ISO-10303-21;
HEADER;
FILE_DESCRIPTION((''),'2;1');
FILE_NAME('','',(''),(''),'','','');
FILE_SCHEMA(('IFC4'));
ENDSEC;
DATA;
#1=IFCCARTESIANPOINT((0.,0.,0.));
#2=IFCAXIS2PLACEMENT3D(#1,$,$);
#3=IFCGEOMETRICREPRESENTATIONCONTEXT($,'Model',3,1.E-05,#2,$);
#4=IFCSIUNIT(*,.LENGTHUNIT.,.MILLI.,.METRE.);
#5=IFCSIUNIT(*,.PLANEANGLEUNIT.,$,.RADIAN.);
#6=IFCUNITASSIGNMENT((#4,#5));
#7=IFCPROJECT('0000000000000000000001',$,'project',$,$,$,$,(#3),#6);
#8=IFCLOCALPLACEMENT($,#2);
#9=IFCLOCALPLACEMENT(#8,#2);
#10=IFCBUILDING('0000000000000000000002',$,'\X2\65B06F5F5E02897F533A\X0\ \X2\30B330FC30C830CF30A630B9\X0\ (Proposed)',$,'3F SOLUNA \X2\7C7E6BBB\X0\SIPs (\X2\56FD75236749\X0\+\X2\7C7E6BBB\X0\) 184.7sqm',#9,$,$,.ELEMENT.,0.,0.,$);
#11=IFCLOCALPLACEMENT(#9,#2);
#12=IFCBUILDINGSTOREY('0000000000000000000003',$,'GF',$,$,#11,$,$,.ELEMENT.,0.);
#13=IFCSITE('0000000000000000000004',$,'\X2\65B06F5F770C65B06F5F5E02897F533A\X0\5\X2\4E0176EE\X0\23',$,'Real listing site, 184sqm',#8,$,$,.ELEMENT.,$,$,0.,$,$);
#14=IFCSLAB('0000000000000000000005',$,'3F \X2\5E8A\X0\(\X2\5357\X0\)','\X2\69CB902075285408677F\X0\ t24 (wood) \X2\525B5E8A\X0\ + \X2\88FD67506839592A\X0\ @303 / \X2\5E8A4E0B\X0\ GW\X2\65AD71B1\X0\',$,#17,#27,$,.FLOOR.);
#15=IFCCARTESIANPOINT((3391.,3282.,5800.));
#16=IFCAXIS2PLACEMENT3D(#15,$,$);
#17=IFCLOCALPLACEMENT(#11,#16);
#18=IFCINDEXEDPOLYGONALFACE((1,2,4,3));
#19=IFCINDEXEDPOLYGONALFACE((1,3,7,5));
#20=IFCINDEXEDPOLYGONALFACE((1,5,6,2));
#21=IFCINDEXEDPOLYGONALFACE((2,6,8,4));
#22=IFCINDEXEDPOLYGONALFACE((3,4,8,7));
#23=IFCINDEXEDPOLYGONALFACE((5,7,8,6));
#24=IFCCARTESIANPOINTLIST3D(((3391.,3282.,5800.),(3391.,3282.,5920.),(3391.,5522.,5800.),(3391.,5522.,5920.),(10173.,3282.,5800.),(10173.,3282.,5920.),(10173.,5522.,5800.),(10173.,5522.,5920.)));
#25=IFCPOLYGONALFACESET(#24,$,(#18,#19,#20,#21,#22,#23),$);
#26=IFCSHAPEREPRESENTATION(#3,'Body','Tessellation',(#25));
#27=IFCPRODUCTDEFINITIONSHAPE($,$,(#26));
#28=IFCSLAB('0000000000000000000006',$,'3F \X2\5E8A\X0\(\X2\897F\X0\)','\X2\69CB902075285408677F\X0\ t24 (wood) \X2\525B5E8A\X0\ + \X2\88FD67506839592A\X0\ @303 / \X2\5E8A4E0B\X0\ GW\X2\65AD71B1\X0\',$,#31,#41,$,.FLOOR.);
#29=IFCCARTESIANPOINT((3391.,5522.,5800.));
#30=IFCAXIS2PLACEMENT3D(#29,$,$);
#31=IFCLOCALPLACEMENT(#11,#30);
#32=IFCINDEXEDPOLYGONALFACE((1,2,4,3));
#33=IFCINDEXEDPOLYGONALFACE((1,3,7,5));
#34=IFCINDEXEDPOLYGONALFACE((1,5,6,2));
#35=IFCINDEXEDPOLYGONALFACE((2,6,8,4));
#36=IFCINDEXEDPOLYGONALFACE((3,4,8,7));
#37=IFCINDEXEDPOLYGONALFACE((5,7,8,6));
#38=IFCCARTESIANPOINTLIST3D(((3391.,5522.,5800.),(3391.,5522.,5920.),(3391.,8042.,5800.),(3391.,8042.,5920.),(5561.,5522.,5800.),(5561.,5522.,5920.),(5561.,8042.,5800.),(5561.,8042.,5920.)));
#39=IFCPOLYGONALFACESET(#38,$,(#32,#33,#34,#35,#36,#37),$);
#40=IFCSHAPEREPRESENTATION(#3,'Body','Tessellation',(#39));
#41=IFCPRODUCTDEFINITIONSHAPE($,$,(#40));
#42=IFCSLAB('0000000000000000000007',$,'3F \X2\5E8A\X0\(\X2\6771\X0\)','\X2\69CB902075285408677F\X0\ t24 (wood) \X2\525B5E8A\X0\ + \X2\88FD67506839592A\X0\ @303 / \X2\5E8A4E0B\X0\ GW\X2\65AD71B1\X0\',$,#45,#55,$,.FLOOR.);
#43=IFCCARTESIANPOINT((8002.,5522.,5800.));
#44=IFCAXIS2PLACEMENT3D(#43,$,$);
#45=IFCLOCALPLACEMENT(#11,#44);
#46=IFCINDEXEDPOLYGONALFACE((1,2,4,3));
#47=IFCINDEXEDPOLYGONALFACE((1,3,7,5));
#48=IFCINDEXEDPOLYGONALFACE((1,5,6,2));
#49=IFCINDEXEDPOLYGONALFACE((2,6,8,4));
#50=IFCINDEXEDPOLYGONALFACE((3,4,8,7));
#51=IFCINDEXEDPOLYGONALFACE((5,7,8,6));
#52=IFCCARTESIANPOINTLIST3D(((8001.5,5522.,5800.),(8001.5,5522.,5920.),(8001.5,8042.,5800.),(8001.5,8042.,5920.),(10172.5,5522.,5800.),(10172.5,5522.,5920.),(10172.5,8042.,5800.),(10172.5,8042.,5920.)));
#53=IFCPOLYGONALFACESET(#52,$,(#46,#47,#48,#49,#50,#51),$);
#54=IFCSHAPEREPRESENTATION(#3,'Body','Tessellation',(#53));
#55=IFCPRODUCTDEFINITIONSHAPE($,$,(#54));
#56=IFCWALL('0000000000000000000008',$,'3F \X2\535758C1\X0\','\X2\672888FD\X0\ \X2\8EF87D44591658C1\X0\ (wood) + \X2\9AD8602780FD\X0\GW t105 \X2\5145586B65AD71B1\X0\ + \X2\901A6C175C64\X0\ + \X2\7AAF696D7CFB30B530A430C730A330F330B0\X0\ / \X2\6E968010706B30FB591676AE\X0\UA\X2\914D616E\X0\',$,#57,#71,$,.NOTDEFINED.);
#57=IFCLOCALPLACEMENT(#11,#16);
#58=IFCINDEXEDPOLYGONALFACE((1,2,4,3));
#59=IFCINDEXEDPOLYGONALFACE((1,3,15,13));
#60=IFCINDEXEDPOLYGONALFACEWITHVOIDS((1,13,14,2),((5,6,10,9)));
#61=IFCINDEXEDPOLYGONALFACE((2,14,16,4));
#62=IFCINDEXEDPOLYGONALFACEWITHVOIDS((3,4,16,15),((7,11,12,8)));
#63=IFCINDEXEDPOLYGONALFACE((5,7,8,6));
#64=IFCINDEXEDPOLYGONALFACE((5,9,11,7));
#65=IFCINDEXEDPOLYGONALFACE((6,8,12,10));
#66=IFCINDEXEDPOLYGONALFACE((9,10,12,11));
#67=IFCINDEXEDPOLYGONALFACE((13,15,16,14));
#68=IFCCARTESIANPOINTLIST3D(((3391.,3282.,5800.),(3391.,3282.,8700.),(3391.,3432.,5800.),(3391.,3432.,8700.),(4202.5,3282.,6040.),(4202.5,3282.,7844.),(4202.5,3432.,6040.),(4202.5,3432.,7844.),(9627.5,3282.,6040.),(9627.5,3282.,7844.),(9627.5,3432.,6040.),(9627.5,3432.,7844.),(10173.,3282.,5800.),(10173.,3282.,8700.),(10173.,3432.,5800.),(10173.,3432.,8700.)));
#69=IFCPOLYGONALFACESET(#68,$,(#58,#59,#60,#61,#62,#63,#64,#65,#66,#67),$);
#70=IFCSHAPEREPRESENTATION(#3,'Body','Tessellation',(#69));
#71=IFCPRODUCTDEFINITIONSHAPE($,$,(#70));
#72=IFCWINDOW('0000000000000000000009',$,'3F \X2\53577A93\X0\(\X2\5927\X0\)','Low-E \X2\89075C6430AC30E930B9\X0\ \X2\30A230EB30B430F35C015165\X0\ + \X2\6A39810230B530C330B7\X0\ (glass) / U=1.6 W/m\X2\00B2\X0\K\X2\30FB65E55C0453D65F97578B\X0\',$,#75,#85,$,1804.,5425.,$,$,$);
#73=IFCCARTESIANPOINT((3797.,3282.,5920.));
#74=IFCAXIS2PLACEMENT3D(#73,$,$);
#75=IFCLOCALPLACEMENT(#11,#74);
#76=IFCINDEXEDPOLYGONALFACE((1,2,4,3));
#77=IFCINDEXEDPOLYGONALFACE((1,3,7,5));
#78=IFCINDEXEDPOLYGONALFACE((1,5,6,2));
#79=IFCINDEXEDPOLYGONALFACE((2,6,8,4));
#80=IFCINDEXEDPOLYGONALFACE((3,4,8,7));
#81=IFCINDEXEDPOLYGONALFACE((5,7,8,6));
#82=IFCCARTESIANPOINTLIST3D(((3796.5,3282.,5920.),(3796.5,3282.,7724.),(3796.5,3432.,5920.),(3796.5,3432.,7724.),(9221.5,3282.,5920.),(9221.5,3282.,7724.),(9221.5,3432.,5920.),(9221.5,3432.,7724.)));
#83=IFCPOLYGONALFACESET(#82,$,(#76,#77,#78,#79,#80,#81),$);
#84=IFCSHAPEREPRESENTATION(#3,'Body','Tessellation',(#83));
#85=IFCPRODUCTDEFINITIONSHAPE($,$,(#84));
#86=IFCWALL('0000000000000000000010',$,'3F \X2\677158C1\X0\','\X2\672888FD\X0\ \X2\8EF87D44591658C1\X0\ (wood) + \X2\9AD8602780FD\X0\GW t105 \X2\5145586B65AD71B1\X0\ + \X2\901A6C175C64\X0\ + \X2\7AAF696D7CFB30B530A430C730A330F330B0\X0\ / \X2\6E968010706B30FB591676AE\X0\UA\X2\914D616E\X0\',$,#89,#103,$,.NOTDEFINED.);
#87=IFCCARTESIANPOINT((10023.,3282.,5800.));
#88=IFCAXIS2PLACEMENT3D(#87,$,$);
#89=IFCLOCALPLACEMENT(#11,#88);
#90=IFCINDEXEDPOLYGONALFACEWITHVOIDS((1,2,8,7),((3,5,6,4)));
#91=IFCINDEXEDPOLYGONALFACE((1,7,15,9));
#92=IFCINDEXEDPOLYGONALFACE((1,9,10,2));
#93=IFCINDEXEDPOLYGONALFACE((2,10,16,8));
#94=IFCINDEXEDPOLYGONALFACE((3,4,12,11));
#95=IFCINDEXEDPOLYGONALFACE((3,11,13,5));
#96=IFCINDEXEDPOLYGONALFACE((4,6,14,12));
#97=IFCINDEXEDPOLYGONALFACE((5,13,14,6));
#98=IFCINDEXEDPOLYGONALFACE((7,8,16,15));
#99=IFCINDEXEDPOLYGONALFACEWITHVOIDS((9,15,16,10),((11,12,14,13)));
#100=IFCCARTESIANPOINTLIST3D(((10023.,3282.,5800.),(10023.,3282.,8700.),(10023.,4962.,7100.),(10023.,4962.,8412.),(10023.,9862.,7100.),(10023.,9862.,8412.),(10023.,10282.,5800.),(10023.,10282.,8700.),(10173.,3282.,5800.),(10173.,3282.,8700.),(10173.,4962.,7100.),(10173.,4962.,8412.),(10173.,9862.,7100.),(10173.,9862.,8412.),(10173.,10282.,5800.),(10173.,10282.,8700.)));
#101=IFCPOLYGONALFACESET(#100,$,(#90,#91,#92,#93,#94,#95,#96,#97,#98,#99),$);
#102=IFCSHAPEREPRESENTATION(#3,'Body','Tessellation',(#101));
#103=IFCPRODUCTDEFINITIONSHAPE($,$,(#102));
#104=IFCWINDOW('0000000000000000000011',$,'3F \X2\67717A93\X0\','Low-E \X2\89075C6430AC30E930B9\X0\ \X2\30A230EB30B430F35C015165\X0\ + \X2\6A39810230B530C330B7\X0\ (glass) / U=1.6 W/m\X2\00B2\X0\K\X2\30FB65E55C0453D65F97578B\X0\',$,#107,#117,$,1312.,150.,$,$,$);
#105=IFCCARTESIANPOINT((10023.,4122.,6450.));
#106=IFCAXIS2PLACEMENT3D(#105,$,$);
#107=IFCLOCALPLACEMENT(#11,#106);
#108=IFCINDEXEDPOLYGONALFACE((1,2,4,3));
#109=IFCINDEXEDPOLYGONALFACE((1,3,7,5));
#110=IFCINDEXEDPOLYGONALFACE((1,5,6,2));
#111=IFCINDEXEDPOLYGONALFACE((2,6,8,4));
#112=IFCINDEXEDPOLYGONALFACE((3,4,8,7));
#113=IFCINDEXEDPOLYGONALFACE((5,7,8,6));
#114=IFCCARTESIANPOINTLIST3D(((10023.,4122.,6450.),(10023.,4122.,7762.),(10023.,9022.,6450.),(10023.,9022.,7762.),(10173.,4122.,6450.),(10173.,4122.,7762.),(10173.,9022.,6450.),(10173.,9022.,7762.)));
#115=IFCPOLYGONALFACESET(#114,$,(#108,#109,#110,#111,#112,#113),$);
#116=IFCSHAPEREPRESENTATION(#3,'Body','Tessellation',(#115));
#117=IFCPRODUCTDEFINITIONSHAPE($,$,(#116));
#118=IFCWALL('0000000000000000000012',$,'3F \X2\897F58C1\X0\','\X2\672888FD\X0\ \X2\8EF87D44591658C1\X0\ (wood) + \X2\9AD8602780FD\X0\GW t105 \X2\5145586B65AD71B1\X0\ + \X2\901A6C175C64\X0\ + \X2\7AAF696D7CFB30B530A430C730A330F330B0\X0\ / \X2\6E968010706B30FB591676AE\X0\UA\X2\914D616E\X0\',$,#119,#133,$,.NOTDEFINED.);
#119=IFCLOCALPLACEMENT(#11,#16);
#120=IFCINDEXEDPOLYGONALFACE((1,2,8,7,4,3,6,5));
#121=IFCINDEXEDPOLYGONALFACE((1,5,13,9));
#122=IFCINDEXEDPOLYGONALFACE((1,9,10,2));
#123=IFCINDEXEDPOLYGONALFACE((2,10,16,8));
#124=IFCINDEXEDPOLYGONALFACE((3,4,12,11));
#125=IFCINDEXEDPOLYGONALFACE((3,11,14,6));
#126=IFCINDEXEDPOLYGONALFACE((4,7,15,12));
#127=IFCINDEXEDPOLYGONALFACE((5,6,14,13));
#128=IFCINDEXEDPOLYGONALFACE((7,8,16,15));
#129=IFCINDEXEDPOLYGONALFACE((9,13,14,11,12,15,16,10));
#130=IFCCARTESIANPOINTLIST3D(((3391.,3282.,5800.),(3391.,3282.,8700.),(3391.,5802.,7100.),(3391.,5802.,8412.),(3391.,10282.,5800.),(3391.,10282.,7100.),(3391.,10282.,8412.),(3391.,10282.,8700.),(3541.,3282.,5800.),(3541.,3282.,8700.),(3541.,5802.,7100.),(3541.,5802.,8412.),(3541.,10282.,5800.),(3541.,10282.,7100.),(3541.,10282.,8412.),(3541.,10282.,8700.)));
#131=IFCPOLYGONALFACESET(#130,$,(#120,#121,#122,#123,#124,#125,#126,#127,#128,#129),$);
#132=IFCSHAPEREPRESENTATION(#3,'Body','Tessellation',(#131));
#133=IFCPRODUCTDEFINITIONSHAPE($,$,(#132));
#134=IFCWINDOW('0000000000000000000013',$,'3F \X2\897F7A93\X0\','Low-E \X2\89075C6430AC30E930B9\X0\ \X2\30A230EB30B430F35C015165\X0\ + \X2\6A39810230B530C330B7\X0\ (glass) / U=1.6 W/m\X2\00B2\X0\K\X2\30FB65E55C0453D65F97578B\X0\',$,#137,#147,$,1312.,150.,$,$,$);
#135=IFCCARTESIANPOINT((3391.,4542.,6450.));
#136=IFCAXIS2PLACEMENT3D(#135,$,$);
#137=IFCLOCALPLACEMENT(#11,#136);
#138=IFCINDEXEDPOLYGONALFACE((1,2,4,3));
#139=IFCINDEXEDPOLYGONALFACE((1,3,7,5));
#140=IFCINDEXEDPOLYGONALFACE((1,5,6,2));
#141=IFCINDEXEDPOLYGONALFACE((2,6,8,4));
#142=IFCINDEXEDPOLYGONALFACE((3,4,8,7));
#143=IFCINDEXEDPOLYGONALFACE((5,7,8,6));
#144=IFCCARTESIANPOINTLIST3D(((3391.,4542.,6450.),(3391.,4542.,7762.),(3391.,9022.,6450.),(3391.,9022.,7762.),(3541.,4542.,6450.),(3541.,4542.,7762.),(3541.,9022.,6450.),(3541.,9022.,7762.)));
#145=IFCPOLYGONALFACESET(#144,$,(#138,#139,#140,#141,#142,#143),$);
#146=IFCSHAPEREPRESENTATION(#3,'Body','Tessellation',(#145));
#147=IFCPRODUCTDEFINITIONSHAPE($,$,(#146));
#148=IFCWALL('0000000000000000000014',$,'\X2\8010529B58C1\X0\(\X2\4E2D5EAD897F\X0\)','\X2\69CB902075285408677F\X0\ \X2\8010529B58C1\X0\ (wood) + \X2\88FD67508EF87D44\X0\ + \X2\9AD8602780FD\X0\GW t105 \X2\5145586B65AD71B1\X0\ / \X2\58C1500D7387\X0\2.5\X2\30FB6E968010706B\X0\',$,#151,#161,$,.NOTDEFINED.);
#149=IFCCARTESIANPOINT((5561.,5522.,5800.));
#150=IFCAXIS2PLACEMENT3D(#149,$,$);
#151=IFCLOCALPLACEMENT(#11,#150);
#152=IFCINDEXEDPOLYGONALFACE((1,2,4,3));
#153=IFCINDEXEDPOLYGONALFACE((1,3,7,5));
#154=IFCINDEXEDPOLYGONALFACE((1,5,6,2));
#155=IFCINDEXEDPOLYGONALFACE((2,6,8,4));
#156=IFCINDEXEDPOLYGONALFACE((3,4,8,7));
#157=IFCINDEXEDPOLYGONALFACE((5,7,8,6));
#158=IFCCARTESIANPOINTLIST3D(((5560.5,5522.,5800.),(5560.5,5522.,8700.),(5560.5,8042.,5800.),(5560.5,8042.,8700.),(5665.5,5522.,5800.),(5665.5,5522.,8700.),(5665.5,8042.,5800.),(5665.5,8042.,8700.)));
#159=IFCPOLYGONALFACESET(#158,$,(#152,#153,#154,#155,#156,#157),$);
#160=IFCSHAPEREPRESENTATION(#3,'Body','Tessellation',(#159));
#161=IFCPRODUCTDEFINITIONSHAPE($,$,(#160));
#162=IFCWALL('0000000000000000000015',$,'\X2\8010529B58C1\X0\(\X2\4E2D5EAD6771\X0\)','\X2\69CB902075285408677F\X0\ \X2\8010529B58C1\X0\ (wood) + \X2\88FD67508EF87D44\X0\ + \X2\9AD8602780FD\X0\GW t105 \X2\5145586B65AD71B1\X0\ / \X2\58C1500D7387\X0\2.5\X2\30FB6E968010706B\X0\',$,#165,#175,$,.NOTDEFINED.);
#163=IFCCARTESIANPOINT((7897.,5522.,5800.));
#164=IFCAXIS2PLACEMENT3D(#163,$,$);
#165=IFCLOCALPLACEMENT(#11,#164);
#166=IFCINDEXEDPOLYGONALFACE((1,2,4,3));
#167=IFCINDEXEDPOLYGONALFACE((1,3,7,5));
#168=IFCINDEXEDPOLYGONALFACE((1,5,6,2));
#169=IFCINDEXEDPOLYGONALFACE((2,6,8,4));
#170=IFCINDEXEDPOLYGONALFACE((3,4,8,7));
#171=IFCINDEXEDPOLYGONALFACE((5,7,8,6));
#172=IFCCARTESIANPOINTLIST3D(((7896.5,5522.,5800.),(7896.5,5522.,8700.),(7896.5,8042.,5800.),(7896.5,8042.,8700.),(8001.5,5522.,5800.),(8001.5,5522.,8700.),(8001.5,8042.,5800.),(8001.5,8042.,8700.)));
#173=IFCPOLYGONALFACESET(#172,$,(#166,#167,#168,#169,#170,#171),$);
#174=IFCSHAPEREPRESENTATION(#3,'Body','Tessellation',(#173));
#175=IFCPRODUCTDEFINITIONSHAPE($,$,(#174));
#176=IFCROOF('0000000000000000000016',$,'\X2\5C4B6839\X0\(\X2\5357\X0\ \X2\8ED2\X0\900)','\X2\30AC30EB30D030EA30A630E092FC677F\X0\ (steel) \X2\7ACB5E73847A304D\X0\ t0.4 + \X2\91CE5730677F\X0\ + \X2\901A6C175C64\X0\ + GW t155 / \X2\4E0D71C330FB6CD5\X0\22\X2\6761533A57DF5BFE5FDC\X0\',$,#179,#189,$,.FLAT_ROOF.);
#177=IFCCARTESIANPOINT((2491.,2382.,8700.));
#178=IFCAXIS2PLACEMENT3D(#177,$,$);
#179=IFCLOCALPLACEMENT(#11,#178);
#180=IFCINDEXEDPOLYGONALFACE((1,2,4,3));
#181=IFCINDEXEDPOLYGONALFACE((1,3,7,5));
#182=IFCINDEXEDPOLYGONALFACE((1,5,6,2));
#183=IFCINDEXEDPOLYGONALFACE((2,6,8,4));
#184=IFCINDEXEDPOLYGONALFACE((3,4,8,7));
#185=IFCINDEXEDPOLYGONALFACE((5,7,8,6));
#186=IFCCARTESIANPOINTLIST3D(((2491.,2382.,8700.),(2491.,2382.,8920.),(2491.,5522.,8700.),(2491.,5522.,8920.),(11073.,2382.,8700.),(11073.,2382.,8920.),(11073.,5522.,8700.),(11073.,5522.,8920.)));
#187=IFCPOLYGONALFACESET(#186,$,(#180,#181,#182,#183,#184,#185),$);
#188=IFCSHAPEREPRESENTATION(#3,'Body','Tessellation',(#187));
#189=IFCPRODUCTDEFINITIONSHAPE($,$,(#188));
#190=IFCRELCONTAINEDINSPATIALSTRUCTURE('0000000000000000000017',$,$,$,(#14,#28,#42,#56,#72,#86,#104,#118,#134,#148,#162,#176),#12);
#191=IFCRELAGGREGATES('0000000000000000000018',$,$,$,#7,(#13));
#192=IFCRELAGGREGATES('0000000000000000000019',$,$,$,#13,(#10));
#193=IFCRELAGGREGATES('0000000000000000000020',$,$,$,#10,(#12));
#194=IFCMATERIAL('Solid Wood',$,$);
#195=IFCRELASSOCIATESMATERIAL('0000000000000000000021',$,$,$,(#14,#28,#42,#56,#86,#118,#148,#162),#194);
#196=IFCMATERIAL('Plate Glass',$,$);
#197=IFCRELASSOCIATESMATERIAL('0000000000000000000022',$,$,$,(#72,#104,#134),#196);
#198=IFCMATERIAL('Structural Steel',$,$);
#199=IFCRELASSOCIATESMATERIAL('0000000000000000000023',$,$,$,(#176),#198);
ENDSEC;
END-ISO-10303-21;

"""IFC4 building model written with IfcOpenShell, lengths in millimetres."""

from ifc_helpers import new_model, si_unit, frame, frame_2d, origin, place, context, project, spatial, rectangle, extrude, material, element, fill, save


model = new_model("IFC4")

# Units and contexts
model_context = context("Model", 3, precision=1e-05, world=origin())
ifc_project = project(units=[si_unit("LENGTHUNIT", "METRE", prefix="MILLI"), si_unit("PLANEANGLEUNIT", "RADIAN")], contexts=[model_context])

# Site, building, storey
site_placement = place(None, origin())
site = spatial("IfcSite", under=ifc_project, at=site_placement, Name="新潟県新潟市西区5丁目23", ObjectType="Real listing site, 184sqm", CompositionType="ELEMENT", RefElevation=0.0)
building_placement = place(site_placement, origin())
building = spatial("IfcBuilding", under=site, at=building_placement, Name="新潟市西区 コートハウス (Proposed)", ObjectType="3F SOLUNA 籾殻SIPs (国産杉+籾殻) 184.7sqm", CompositionType="ELEMENT", ElevationOfRefHeight=0.0, ElevationOfTerrain=0.0)
storey_placement = place(building_placement, origin())
storey = spatial("IfcBuildingStorey", under=building, at=storey_placement, Name="GF", CompositionType="ELEMENT", Elevation=0.0)

# Slabs
ifc_material_1 = material(Name="Solid Wood")
slab_1_placement = place(storey_placement, frame((3391.0, 3282.0, 5800.0)))
element("IfcSlab", 1, at=slab_1_placement, inside=storey, material=ifc_material_1, Name="3F 床(南)", Description="構造用合板 t24 (wood) 剛床 + 製材根太 @303 / 床下 GW断熱", PredefinedType="FLOOR", context=model_context, shape_type="SweptSolid", body=[
    extrude(rectangle(XDim=6782.0, YDim=2240.0, at=frame_2d((3391.0, 1120.0))), frame((3391.0, 3282.0, 5800.0)), (0.0, 0.0, 1.0), 120.0),
])
slab_2_placement = place(storey_placement, frame((3391.0, 5522.0, 5800.0)))
element("IfcSlab", 2, at=slab_2_placement, inside=storey, material=ifc_material_1, Name="3F 床(西)", Description="構造用合板 t24 (wood) 剛床 + 製材根太 @303 / 床下 GW断熱", PredefinedType="FLOOR", context=model_context, shape_type="SweptSolid", body=[
    extrude(rectangle(XDim=2170.0, YDim=2520.0, at=frame_2d((1085.0, 1260.0))), frame((3391.0, 5522.0, 5800.0)), (0.0, 0.0, 1.0), 120.0),
])
slab_3_placement = place(storey_placement, frame((8002.0, 5522.0, 5800.0)))
element("IfcSlab", 3, at=slab_3_placement, inside=storey, material=ifc_material_1, Name="3F 床(東)", Description="構造用合板 t24 (wood) 剛床 + 製材根太 @303 / 床下 GW断熱", PredefinedType="FLOOR", context=model_context, shape_type="SweptSolid", body=[
    extrude(rectangle(XDim=2171.0, YDim=2520.0, at=frame_2d((1085.0, 1260.0))), frame((8002.0, 5522.0, 5800.0)), (0.0, 0.0, 1.0), 120.0),
])

# Walls, openings, windows
wall_1_placement = place(storey_placement, frame((3391.0, 3282.0, 5800.0)))
wall_1 = element("IfcWall", 4, at=wall_1_placement, inside=storey, material=ifc_material_1, Name="3F 南壁", Description="木製 軸組外壁 (wood) + 高性能GW t105 充填断熱 + 通気層 + 窯業系サイディング / 準耐火・外皮UA配慮", PredefinedType="NOTDEFINED", context=model_context, shape_type="SweptSolid", body=[
    extrude(rectangle(XDim=6782.0, YDim=150.0, at=frame_2d((3391.0, 75.0))), frame((3391.0, 3282.0, 5800.0)), (0.0, 0.0, 1.0), 2900.0),
])
opening_1_placement = place(storey_placement, frame((3797.0, 3282.0, 5920.0)))
opening_1 = element("IfcOpeningElement", 5, at=opening_1_placement, cuts=wall_1, PredefinedType="NOTDEFINED", context=model_context, shape_type="SweptSolid", body=[
    extrude(rectangle(XDim=5425.0, YDim=150.0, at=frame_2d((2712.0, 75.0))), frame((3797.0, 3282.0, 5920.0)), (0.0, 0.0, 1.0), 1804.0),
])
ifc_material_2 = material(Name="Plate Glass")
window_1_placement = place(storey_placement, frame((3797.0, 3282.0, 5920.0)))
window_1 = element("IfcWindow", 6, at=window_1_placement, inside=storey, material=ifc_material_2, Name="3F 南窓(大)", Description="Low-E 複層ガラス アルゴン封入 + 樹脂サッシ (glass) / U=1.6 W/m²K・日射取得型", OverallHeight=1804.0, OverallWidth=5425.0, context=model_context, shape_type="SweptSolid", body=[
    extrude(rectangle(XDim=5425.0, YDim=150.0, at=frame_2d((2712.0, 75.0))), frame((3797.0, 3282.0, 5920.0)), (0.0, 0.0, 1.0), 1804.0),
])
fill(opening_1, window_1)
wall_2_placement = place(storey_placement, frame((10023.0, 3282.0, 5800.0)))
wall_2 = element("IfcWall", 7, at=wall_2_placement, inside=storey, material=ifc_material_1, Name="3F 東壁", Description="木製 軸組外壁 (wood) + 高性能GW t105 充填断熱 + 通気層 + 窯業系サイディング / 準耐火・外皮UA配慮", PredefinedType="NOTDEFINED", context=model_context, shape_type="SweptSolid", body=[
    extrude(rectangle(XDim=150.0, YDim=7000.0, at=frame_2d((75.0, 3500.0))), frame((10023.0, 3282.0, 5800.0)), (0.0, 0.0, 1.0), 2900.0),
])
opening_2_placement = place(storey_placement, frame((10023.0, 4122.0, 6450.0)))
opening_2 = element("IfcOpeningElement", 8, at=opening_2_placement, cuts=wall_2, PredefinedType="NOTDEFINED", context=model_context, shape_type="SweptSolid", body=[
    extrude(rectangle(XDim=150.0, YDim=4900.0, at=frame_2d((75.0, 2450.0))), frame((10023.0, 4122.0, 6450.0)), (0.0, 0.0, 1.0), 1312.0),
])
window_2_placement = place(storey_placement, frame((10023.0, 4122.0, 6450.0)))
window_2 = element("IfcWindow", 9, at=window_2_placement, inside=storey, material=ifc_material_2, Name="3F 東窓", Description="Low-E 複層ガラス アルゴン封入 + 樹脂サッシ (glass) / U=1.6 W/m²K・日射取得型", OverallHeight=1312.0, OverallWidth=150.0, context=model_context, shape_type="SweptSolid", body=[
    extrude(rectangle(XDim=150.0, YDim=4900.0, at=frame_2d((75.0, 2450.0))), frame((10023.0, 4122.0, 6450.0)), (0.0, 0.0, 1.0), 1312.0),
])
fill(opening_2, window_2)
wall_3_placement = place(storey_placement, frame((3391.0, 3282.0, 5800.0)))
wall_3 = element("IfcWall", 10, at=wall_3_placement, inside=storey, material=ifc_material_1, Name="3F 西壁", Description="木製 軸組外壁 (wood) + 高性能GW t105 充填断熱 + 通気層 + 窯業系サイディング / 準耐火・外皮UA配慮", PredefinedType="NOTDEFINED", context=model_context, shape_type="SweptSolid", body=[
    extrude(rectangle(XDim=150.0, YDim=7000.0, at=frame_2d((75.0, 3500.0))), frame((3391.0, 3282.0, 5800.0)), (0.0, 0.0, 1.0), 2900.0),
])
opening_3_placement = place(storey_placement, frame((3391.0, 4542.0, 6450.0)))
opening_3 = element("IfcOpeningElement", 11, at=opening_3_placement, cuts=wall_3, PredefinedType="NOTDEFINED", context=model_context, shape_type="SweptSolid", body=[
    extrude(rectangle(XDim=150.0, YDim=4480.0, at=frame_2d((75.0, 2240.0))), frame((3391.0, 4542.0, 6450.0)), (0.0, 0.0, 1.0), 1312.0),
])
window_3_placement = place(storey_placement, frame((3391.0, 4542.0, 6450.0)))
window_3 = element("IfcWindow", 12, at=window_3_placement, inside=storey, material=ifc_material_2, Name="3F 西窓", Description="Low-E 複層ガラス アルゴン封入 + 樹脂サッシ (glass) / U=1.6 W/m²K・日射取得型", OverallHeight=1312.0, OverallWidth=150.0, context=model_context, shape_type="SweptSolid", body=[
    extrude(rectangle(XDim=150.0, YDim=4480.0, at=frame_2d((75.0, 2240.0))), frame((3391.0, 4542.0, 6450.0)), (0.0, 0.0, 1.0), 1312.0),
])
fill(opening_3, window_3)

# Walls
wall_4_placement = place(storey_placement, frame((5561.0, 5522.0, 5800.0)))
element("IfcWall", 13, at=wall_4_placement, inside=storey, material=ifc_material_1, Name="耐力壁(中庭西)", Description="構造用合板 耐力壁 (wood) + 製材軸組 + 高性能GW t105 充填断熱 / 壁倍率2.5・準耐火", PredefinedType="NOTDEFINED", context=model_context, shape_type="SweptSolid", body=[
    extrude(rectangle(XDim=105.0, YDim=2520.0, at=frame_2d((52.0, 1260.0))), frame((5561.0, 5522.0, 5800.0)), (0.0, 0.0, 1.0), 2900.0),
])
wall_5_placement = place(storey_placement, frame((7897.0, 5522.0, 5800.0)))
element("IfcWall", 14, at=wall_5_placement, inside=storey, material=ifc_material_1, Name="耐力壁(中庭東)", Description="構造用合板 耐力壁 (wood) + 製材軸組 + 高性能GW t105 充填断熱 / 壁倍率2.5・準耐火", PredefinedType="NOTDEFINED", context=model_context, shape_type="SweptSolid", body=[
    extrude(rectangle(XDim=105.0, YDim=2520.0, at=frame_2d((52.0, 1260.0))), frame((7897.0, 5522.0, 5800.0)), (0.0, 0.0, 1.0), 2900.0),
])

# Roof
ifc_material_3 = material(Name="Structural Steel")
roof_1_placement = place(storey_placement, frame((2491.0, 2382.0, 8700.0)))
element("IfcRoof", 15, at=roof_1_placement, inside=storey, material=ifc_material_3, Name="屋根(南 軒900)", Description="ガルバリウム鋼板 (steel) 立平葺き t0.4 + 野地板 + 通気層 + GW t155 / 不燃・法22条区域対応", PredefinedType="FLAT_ROOF", context=model_context, shape_type="SweptSolid", body=[
    extrude(rectangle(XDim=8582.0, YDim=3140.0, at=frame_2d((4291.0, 1570.0))), frame((2491.0, 2382.0, 8700.0)), (0.0, 0.0, 1.0), 220.0),
])

save(model, "model.ifc")
